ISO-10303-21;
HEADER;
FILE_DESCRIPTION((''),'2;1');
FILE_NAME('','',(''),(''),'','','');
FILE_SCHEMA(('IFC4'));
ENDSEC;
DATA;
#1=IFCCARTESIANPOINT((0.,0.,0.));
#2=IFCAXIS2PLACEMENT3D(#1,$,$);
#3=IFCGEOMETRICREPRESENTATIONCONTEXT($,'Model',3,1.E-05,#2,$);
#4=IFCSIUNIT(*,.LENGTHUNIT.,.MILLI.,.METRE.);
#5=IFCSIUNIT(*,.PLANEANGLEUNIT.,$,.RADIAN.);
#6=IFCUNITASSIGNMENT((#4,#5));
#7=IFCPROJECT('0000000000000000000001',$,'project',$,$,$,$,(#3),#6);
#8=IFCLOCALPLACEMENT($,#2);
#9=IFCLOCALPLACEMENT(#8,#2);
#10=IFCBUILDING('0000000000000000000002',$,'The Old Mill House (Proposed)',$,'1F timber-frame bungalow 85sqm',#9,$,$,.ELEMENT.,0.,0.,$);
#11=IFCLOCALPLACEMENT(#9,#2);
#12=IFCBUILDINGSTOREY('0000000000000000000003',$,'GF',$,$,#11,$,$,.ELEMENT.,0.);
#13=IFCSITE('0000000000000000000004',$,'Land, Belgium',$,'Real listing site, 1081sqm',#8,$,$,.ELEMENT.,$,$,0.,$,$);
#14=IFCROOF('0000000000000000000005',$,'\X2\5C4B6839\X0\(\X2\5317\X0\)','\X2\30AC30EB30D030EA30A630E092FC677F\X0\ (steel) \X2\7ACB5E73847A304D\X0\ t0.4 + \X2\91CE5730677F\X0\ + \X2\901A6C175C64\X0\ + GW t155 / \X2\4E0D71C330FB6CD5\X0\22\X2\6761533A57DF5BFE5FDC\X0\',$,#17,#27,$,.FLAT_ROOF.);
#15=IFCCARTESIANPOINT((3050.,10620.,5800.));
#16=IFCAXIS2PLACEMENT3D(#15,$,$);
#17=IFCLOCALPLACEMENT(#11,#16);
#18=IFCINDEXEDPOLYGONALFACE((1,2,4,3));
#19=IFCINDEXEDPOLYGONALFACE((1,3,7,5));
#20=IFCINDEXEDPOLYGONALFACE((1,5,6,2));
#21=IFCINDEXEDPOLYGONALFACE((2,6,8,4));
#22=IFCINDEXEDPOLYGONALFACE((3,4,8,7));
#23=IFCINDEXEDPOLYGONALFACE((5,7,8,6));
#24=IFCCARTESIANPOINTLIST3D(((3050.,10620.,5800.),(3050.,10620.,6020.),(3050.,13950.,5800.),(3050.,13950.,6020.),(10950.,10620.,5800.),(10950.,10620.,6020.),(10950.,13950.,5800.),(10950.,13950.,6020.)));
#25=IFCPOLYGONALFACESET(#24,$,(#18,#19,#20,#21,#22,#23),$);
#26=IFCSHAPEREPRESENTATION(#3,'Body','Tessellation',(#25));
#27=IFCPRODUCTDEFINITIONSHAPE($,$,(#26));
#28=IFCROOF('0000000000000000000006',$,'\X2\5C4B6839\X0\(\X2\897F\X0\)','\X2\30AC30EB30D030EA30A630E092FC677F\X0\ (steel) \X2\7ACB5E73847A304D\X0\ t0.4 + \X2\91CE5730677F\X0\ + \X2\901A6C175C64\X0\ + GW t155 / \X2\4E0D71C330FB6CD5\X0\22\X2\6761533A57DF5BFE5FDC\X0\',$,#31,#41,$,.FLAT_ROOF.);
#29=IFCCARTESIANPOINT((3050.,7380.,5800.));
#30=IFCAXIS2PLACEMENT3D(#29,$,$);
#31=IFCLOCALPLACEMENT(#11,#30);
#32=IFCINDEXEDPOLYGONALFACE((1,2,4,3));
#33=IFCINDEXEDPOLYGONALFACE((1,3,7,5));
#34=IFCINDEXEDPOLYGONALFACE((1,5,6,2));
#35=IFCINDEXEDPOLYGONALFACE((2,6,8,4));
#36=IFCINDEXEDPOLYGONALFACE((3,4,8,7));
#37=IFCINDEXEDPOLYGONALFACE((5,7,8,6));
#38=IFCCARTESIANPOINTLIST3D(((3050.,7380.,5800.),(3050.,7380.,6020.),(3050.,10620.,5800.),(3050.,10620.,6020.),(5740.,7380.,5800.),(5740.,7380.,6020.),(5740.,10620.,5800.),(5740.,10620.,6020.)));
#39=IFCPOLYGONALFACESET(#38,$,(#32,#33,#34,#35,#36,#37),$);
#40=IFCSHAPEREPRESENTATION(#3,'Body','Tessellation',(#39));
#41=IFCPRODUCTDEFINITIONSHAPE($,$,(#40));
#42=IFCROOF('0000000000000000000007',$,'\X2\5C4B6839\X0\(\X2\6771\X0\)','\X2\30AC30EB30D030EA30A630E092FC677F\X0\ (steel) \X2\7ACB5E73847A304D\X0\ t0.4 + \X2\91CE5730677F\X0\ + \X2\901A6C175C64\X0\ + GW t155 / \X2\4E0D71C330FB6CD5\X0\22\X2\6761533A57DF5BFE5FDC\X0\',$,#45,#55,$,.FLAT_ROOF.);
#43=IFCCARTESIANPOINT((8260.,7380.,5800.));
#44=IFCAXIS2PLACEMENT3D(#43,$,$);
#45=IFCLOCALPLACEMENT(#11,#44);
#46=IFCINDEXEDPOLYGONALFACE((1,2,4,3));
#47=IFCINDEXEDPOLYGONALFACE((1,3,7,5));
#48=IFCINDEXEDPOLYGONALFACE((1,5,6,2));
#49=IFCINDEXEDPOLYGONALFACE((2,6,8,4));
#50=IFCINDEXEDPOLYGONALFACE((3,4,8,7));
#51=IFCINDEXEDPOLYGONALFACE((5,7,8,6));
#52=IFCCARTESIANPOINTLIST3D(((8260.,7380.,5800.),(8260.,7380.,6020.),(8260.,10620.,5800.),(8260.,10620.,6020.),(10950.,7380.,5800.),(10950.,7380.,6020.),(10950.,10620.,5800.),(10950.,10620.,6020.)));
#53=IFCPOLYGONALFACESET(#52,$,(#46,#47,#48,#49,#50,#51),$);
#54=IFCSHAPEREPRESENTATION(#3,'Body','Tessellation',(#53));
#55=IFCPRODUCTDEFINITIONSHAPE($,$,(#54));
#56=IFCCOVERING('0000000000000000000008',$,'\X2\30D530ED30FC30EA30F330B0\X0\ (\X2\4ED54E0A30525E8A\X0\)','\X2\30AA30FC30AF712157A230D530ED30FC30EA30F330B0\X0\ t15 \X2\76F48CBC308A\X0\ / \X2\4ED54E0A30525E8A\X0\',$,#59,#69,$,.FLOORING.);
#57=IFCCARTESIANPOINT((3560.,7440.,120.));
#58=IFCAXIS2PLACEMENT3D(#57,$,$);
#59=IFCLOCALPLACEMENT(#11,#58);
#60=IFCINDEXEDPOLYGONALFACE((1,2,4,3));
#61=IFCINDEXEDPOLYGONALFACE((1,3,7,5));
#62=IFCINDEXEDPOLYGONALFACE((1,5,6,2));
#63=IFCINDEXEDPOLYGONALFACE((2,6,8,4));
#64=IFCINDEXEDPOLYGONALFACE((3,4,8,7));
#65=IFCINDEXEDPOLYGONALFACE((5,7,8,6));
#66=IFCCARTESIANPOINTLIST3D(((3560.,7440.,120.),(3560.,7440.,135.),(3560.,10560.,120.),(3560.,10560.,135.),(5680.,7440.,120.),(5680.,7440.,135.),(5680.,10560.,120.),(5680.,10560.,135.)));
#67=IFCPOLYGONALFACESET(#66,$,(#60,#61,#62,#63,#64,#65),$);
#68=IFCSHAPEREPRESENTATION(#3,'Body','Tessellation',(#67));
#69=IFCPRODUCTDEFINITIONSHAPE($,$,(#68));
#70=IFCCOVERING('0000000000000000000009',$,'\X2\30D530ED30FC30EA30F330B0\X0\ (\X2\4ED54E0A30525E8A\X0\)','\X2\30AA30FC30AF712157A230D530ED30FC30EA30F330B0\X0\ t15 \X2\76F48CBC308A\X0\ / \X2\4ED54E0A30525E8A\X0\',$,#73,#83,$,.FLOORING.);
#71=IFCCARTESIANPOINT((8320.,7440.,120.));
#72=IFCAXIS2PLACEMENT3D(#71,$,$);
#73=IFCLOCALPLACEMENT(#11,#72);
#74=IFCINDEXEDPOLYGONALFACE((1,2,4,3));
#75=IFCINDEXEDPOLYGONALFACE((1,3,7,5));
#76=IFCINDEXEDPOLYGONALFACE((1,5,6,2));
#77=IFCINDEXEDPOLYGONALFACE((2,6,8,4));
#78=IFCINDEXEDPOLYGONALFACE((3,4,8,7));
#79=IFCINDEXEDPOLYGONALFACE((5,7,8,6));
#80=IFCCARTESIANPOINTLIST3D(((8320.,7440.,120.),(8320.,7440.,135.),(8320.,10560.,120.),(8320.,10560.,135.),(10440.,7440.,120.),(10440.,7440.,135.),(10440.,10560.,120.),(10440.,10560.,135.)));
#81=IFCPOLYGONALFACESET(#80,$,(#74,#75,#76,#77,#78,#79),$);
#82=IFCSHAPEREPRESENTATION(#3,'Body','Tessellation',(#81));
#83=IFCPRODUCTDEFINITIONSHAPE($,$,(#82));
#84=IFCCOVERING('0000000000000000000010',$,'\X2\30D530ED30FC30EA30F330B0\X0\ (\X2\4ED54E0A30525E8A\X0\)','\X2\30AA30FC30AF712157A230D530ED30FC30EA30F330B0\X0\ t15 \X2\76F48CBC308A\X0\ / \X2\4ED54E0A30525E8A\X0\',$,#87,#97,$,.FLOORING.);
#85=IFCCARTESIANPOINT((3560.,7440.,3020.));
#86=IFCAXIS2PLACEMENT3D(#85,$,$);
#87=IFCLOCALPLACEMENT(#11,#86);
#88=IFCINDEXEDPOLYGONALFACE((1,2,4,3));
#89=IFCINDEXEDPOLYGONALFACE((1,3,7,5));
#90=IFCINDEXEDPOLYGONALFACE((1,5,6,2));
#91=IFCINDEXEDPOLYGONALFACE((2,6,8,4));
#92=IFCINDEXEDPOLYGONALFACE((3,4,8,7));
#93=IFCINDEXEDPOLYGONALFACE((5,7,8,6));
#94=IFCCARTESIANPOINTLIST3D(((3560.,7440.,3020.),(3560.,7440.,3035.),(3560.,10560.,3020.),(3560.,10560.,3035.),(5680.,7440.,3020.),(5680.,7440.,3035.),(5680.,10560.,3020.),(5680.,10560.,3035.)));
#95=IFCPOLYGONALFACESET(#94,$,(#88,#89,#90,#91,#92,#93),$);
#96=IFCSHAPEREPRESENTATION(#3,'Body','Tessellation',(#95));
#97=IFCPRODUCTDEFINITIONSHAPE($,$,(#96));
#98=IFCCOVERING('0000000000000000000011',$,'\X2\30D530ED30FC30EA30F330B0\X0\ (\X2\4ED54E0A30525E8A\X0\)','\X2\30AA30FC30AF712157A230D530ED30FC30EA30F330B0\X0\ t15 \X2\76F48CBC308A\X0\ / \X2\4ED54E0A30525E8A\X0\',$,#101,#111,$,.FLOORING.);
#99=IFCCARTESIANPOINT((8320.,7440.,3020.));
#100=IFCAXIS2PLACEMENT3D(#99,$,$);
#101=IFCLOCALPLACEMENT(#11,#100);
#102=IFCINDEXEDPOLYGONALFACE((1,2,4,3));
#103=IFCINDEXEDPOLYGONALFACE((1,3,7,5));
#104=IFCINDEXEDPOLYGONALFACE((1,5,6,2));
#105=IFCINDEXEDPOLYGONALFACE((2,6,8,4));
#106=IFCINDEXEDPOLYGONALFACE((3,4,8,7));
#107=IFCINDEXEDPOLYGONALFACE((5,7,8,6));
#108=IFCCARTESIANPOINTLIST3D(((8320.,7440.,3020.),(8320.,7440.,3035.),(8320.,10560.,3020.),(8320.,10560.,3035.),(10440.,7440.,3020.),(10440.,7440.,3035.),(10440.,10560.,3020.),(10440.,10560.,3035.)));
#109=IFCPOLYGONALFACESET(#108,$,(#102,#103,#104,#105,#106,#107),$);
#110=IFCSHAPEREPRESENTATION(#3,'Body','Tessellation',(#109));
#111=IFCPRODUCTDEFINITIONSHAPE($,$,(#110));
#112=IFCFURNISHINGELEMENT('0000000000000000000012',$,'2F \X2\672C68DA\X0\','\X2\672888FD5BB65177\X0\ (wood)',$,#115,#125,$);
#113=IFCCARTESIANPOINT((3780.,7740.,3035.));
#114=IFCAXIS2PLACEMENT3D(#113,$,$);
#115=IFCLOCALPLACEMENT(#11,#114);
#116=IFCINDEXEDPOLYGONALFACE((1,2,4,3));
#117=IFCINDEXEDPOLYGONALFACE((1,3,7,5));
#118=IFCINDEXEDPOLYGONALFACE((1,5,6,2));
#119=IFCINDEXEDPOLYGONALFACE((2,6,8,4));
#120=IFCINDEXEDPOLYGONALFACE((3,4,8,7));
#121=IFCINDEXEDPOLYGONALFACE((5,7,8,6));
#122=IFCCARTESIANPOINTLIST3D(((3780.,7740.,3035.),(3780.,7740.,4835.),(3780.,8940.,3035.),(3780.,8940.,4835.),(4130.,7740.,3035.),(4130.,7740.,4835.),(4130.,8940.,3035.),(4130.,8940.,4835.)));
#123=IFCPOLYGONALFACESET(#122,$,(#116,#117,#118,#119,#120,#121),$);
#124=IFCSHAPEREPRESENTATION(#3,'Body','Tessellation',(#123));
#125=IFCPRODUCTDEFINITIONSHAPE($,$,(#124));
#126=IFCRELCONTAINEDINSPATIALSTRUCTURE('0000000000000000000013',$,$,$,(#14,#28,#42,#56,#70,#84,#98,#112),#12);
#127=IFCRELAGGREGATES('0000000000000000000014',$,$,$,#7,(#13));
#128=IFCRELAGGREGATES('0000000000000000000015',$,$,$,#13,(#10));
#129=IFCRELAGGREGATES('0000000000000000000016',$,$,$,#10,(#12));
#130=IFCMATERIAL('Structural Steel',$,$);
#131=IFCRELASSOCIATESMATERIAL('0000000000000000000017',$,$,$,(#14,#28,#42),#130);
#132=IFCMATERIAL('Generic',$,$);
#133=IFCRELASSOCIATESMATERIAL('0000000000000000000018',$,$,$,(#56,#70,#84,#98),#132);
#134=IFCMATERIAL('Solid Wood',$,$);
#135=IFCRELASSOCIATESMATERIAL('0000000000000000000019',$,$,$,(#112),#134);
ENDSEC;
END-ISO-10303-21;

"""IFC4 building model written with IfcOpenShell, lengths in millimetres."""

from ifc_helpers import new_model, si_unit, frame, frame_2d, origin, place, context, project, spatial, rectangle, extrude, material, element, save


model = new_model("IFC4")

# Units and contexts
model_context = context("Model", 3, precision=1e-05, world=origin())
ifc_project = project(units=[si_unit("LENGTHUNIT", "METRE", prefix="MILLI"), si_unit("PLANEANGLEUNIT", "RADIAN")], contexts=[model_context])

# Site, building, storey
site_placement = place(None, origin())
site = spatial("IfcSite", under=ifc_project, at=site_placement, Name="Land, Belgium", ObjectType="Real listing site, 1081sqm", CompositionType="ELEMENT", RefElevation=0.0)
building_placement = place(site_placement, origin())
building = spatial("IfcBuilding", under=site, at=building_placement, Name="The Old Mill House (Proposed)", ObjectType="1F timber-frame bungalow 85sqm", CompositionType="ELEMENT", ElevationOfRefHeight=0.0, ElevationOfTerrain=0.0)
storey_placement = place(building_placement, origin())
storey = spatial("IfcBuildingStorey", under=building, at=storey_placement, Name="GF", CompositionType="ELEMENT", Elevation=0.0)

# Shared definitions
ifc_material_1 = material(Name="Solid Wood")

# Shared definitions
ifc_material_2 = material(Name="Generic")

# Roofs
ifc_material_3 = material(Name="Structural Steel")
roof_1_placement = place(storey_placement, frame((3050.0, 10620.0, 5800.0)))
element("IfcRoof", 1, at=roof_1_placement, inside=storey, material=ifc_material_3, Name="屋根(北)", Description="ガルバリウム鋼板 (steel) 立平葺き t0.4 + 野地板 + 通気層 + GW t155 / 不燃・法22条区域対応", PredefinedType="FLAT_ROOF", context=model_context, shape_type="SweptSolid", body=[
    extrude(rectangle(XDim=7900.0, YDim=3330.0, at=frame_2d((3950.0, 1665.0))), frame((3050.0, 10620.0, 5800.0)), (0.0, 0.0, 1.0), 220.0),
])
roof_2_placement = place(storey_placement, frame((3050.0, 7380.0, 5800.0)))
element("IfcRoof", 2, at=roof_2_placement, inside=storey, material=ifc_material_3, Name="屋根(西)", Description="ガルバリウム鋼板 (steel) 立平葺き t0.4 + 野地板 + 通気層 + GW t155 / 不燃・法22条区域対応", PredefinedType="FLAT_ROOF", context=model_context, shape_type="SweptSolid", body=[
    extrude(rectangle(XDim=2690.0, YDim=3240.0, at=frame_2d((1345.0, 1620.0))), frame((3050.0, 7380.0, 5800.0)), (0.0, 0.0, 1.0), 220.0),
])
roof_3_placement = place(storey_placement, frame((8260.0, 7380.0, 5800.0)))
element("IfcRoof", 3, at=roof_3_placement, inside=storey, material=ifc_material_3, Name="屋根(東)", Description="ガルバリウム鋼板 (steel) 立平葺き t0.4 + 野地板 + 通気層 + GW t155 / 不燃・法22条区域対応", PredefinedType="FLAT_ROOF", context=model_context, shape_type="SweptSolid", body=[
    extrude(rectangle(XDim=2690.0, YDim=3240.0, at=frame_2d((1345.0, 1620.0))), frame((8260.0, 7380.0, 5800.0)), (0.0, 0.0, 1.0), 220.0),
])

# Coverings
covering_1_placement = place(storey_placement, frame((3560.0, 7440.0, 120.0)))
element("IfcCovering", 4, at=covering_1_placement, inside=storey, material=ifc_material_2, Name="フローリング (仕上げ床)", Description="オーク無垢フローリング t15 直貼り / 仕上げ床", PredefinedType="FLOORING", context=model_context, shape_type="SweptSolid", body=[
    extrude(rectangle(XDim=2120.0, YDim=3120.0, at=frame_2d((1060.0, 1560.0))), frame((3560.0, 7440.0, 120.0)), (0.0, 0.0, 1.0), 15.0),
])
covering_2_placement = place(storey_placement, frame((8320.0, 7440.0, 120.0)))
element("IfcCovering", 5, at=covering_2_placement, inside=storey, material=ifc_material_2, Name="フローリング (仕上げ床)", Description="オーク無垢フローリング t15 直貼り / 仕上げ床", PredefinedType="FLOORING", context=model_context, shape_type="SweptSolid", body=[
    extrude(rectangle(XDim=2120.0, YDim=3120.0, at=frame_2d((1060.0, 1560.0))), frame((8320.0, 7440.0, 120.0)), (0.0, 0.0, 1.0), 15.0),
])
covering_3_placement = place(storey_placement, frame((3560.0, 7440.0, 3020.0)))
element("IfcCovering", 6, at=covering_3_placement, inside=storey, material=ifc_material_2, Name="フローリング (仕上げ床)", Description="オーク無垢フローリング t15 直貼り / 仕上げ床", PredefinedType="FLOORING", context=model_context, shape_type="SweptSolid", body=[
    extrude(rectangle(XDim=2120.0, YDim=3120.0, at=frame_2d((1060.0, 1560.0))), frame((3560.0, 7440.0, 3020.0)), (0.0, 0.0, 1.0), 15.0),
])
covering_4_placement = place(storey_placement, frame((8320.0, 7440.0, 3020.0)))
element("IfcCovering", 7, at=covering_4_placement, inside=storey, material=ifc_material_2, Name="フローリング (仕上げ床)", Description="オーク無垢フローリング t15 直貼り / 仕上げ床", PredefinedType="FLOORING", context=model_context, shape_type="SweptSolid", body=[
    extrude(rectangle(XDim=2120.0, YDim=3120.0, at=frame_2d((1060.0, 1560.0))), frame((8320.0, 7440.0, 3020.0)), (0.0, 0.0, 1.0), 15.0),
])

# Furnishing element
furnishing_placement = place(storey_placement, frame((3780.0, 7740.0, 3035.0)))
element("IfcFurnishingElement", 8, at=furnishing_placement, inside=storey, material=ifc_material_1, Name="2F 本棚", Description="木製家具 (wood)", context=model_context, shape_type="SweptSolid", body=[
    extrude(rectangle(XDim=350.0, YDim=1200.0, at=frame_2d((175.0, 600.0))), frame((3780.0, 7740.0, 3035.0)), (0.0, 0.0, 1.0), 1800.0),
])

save(model, "model.ifc")
